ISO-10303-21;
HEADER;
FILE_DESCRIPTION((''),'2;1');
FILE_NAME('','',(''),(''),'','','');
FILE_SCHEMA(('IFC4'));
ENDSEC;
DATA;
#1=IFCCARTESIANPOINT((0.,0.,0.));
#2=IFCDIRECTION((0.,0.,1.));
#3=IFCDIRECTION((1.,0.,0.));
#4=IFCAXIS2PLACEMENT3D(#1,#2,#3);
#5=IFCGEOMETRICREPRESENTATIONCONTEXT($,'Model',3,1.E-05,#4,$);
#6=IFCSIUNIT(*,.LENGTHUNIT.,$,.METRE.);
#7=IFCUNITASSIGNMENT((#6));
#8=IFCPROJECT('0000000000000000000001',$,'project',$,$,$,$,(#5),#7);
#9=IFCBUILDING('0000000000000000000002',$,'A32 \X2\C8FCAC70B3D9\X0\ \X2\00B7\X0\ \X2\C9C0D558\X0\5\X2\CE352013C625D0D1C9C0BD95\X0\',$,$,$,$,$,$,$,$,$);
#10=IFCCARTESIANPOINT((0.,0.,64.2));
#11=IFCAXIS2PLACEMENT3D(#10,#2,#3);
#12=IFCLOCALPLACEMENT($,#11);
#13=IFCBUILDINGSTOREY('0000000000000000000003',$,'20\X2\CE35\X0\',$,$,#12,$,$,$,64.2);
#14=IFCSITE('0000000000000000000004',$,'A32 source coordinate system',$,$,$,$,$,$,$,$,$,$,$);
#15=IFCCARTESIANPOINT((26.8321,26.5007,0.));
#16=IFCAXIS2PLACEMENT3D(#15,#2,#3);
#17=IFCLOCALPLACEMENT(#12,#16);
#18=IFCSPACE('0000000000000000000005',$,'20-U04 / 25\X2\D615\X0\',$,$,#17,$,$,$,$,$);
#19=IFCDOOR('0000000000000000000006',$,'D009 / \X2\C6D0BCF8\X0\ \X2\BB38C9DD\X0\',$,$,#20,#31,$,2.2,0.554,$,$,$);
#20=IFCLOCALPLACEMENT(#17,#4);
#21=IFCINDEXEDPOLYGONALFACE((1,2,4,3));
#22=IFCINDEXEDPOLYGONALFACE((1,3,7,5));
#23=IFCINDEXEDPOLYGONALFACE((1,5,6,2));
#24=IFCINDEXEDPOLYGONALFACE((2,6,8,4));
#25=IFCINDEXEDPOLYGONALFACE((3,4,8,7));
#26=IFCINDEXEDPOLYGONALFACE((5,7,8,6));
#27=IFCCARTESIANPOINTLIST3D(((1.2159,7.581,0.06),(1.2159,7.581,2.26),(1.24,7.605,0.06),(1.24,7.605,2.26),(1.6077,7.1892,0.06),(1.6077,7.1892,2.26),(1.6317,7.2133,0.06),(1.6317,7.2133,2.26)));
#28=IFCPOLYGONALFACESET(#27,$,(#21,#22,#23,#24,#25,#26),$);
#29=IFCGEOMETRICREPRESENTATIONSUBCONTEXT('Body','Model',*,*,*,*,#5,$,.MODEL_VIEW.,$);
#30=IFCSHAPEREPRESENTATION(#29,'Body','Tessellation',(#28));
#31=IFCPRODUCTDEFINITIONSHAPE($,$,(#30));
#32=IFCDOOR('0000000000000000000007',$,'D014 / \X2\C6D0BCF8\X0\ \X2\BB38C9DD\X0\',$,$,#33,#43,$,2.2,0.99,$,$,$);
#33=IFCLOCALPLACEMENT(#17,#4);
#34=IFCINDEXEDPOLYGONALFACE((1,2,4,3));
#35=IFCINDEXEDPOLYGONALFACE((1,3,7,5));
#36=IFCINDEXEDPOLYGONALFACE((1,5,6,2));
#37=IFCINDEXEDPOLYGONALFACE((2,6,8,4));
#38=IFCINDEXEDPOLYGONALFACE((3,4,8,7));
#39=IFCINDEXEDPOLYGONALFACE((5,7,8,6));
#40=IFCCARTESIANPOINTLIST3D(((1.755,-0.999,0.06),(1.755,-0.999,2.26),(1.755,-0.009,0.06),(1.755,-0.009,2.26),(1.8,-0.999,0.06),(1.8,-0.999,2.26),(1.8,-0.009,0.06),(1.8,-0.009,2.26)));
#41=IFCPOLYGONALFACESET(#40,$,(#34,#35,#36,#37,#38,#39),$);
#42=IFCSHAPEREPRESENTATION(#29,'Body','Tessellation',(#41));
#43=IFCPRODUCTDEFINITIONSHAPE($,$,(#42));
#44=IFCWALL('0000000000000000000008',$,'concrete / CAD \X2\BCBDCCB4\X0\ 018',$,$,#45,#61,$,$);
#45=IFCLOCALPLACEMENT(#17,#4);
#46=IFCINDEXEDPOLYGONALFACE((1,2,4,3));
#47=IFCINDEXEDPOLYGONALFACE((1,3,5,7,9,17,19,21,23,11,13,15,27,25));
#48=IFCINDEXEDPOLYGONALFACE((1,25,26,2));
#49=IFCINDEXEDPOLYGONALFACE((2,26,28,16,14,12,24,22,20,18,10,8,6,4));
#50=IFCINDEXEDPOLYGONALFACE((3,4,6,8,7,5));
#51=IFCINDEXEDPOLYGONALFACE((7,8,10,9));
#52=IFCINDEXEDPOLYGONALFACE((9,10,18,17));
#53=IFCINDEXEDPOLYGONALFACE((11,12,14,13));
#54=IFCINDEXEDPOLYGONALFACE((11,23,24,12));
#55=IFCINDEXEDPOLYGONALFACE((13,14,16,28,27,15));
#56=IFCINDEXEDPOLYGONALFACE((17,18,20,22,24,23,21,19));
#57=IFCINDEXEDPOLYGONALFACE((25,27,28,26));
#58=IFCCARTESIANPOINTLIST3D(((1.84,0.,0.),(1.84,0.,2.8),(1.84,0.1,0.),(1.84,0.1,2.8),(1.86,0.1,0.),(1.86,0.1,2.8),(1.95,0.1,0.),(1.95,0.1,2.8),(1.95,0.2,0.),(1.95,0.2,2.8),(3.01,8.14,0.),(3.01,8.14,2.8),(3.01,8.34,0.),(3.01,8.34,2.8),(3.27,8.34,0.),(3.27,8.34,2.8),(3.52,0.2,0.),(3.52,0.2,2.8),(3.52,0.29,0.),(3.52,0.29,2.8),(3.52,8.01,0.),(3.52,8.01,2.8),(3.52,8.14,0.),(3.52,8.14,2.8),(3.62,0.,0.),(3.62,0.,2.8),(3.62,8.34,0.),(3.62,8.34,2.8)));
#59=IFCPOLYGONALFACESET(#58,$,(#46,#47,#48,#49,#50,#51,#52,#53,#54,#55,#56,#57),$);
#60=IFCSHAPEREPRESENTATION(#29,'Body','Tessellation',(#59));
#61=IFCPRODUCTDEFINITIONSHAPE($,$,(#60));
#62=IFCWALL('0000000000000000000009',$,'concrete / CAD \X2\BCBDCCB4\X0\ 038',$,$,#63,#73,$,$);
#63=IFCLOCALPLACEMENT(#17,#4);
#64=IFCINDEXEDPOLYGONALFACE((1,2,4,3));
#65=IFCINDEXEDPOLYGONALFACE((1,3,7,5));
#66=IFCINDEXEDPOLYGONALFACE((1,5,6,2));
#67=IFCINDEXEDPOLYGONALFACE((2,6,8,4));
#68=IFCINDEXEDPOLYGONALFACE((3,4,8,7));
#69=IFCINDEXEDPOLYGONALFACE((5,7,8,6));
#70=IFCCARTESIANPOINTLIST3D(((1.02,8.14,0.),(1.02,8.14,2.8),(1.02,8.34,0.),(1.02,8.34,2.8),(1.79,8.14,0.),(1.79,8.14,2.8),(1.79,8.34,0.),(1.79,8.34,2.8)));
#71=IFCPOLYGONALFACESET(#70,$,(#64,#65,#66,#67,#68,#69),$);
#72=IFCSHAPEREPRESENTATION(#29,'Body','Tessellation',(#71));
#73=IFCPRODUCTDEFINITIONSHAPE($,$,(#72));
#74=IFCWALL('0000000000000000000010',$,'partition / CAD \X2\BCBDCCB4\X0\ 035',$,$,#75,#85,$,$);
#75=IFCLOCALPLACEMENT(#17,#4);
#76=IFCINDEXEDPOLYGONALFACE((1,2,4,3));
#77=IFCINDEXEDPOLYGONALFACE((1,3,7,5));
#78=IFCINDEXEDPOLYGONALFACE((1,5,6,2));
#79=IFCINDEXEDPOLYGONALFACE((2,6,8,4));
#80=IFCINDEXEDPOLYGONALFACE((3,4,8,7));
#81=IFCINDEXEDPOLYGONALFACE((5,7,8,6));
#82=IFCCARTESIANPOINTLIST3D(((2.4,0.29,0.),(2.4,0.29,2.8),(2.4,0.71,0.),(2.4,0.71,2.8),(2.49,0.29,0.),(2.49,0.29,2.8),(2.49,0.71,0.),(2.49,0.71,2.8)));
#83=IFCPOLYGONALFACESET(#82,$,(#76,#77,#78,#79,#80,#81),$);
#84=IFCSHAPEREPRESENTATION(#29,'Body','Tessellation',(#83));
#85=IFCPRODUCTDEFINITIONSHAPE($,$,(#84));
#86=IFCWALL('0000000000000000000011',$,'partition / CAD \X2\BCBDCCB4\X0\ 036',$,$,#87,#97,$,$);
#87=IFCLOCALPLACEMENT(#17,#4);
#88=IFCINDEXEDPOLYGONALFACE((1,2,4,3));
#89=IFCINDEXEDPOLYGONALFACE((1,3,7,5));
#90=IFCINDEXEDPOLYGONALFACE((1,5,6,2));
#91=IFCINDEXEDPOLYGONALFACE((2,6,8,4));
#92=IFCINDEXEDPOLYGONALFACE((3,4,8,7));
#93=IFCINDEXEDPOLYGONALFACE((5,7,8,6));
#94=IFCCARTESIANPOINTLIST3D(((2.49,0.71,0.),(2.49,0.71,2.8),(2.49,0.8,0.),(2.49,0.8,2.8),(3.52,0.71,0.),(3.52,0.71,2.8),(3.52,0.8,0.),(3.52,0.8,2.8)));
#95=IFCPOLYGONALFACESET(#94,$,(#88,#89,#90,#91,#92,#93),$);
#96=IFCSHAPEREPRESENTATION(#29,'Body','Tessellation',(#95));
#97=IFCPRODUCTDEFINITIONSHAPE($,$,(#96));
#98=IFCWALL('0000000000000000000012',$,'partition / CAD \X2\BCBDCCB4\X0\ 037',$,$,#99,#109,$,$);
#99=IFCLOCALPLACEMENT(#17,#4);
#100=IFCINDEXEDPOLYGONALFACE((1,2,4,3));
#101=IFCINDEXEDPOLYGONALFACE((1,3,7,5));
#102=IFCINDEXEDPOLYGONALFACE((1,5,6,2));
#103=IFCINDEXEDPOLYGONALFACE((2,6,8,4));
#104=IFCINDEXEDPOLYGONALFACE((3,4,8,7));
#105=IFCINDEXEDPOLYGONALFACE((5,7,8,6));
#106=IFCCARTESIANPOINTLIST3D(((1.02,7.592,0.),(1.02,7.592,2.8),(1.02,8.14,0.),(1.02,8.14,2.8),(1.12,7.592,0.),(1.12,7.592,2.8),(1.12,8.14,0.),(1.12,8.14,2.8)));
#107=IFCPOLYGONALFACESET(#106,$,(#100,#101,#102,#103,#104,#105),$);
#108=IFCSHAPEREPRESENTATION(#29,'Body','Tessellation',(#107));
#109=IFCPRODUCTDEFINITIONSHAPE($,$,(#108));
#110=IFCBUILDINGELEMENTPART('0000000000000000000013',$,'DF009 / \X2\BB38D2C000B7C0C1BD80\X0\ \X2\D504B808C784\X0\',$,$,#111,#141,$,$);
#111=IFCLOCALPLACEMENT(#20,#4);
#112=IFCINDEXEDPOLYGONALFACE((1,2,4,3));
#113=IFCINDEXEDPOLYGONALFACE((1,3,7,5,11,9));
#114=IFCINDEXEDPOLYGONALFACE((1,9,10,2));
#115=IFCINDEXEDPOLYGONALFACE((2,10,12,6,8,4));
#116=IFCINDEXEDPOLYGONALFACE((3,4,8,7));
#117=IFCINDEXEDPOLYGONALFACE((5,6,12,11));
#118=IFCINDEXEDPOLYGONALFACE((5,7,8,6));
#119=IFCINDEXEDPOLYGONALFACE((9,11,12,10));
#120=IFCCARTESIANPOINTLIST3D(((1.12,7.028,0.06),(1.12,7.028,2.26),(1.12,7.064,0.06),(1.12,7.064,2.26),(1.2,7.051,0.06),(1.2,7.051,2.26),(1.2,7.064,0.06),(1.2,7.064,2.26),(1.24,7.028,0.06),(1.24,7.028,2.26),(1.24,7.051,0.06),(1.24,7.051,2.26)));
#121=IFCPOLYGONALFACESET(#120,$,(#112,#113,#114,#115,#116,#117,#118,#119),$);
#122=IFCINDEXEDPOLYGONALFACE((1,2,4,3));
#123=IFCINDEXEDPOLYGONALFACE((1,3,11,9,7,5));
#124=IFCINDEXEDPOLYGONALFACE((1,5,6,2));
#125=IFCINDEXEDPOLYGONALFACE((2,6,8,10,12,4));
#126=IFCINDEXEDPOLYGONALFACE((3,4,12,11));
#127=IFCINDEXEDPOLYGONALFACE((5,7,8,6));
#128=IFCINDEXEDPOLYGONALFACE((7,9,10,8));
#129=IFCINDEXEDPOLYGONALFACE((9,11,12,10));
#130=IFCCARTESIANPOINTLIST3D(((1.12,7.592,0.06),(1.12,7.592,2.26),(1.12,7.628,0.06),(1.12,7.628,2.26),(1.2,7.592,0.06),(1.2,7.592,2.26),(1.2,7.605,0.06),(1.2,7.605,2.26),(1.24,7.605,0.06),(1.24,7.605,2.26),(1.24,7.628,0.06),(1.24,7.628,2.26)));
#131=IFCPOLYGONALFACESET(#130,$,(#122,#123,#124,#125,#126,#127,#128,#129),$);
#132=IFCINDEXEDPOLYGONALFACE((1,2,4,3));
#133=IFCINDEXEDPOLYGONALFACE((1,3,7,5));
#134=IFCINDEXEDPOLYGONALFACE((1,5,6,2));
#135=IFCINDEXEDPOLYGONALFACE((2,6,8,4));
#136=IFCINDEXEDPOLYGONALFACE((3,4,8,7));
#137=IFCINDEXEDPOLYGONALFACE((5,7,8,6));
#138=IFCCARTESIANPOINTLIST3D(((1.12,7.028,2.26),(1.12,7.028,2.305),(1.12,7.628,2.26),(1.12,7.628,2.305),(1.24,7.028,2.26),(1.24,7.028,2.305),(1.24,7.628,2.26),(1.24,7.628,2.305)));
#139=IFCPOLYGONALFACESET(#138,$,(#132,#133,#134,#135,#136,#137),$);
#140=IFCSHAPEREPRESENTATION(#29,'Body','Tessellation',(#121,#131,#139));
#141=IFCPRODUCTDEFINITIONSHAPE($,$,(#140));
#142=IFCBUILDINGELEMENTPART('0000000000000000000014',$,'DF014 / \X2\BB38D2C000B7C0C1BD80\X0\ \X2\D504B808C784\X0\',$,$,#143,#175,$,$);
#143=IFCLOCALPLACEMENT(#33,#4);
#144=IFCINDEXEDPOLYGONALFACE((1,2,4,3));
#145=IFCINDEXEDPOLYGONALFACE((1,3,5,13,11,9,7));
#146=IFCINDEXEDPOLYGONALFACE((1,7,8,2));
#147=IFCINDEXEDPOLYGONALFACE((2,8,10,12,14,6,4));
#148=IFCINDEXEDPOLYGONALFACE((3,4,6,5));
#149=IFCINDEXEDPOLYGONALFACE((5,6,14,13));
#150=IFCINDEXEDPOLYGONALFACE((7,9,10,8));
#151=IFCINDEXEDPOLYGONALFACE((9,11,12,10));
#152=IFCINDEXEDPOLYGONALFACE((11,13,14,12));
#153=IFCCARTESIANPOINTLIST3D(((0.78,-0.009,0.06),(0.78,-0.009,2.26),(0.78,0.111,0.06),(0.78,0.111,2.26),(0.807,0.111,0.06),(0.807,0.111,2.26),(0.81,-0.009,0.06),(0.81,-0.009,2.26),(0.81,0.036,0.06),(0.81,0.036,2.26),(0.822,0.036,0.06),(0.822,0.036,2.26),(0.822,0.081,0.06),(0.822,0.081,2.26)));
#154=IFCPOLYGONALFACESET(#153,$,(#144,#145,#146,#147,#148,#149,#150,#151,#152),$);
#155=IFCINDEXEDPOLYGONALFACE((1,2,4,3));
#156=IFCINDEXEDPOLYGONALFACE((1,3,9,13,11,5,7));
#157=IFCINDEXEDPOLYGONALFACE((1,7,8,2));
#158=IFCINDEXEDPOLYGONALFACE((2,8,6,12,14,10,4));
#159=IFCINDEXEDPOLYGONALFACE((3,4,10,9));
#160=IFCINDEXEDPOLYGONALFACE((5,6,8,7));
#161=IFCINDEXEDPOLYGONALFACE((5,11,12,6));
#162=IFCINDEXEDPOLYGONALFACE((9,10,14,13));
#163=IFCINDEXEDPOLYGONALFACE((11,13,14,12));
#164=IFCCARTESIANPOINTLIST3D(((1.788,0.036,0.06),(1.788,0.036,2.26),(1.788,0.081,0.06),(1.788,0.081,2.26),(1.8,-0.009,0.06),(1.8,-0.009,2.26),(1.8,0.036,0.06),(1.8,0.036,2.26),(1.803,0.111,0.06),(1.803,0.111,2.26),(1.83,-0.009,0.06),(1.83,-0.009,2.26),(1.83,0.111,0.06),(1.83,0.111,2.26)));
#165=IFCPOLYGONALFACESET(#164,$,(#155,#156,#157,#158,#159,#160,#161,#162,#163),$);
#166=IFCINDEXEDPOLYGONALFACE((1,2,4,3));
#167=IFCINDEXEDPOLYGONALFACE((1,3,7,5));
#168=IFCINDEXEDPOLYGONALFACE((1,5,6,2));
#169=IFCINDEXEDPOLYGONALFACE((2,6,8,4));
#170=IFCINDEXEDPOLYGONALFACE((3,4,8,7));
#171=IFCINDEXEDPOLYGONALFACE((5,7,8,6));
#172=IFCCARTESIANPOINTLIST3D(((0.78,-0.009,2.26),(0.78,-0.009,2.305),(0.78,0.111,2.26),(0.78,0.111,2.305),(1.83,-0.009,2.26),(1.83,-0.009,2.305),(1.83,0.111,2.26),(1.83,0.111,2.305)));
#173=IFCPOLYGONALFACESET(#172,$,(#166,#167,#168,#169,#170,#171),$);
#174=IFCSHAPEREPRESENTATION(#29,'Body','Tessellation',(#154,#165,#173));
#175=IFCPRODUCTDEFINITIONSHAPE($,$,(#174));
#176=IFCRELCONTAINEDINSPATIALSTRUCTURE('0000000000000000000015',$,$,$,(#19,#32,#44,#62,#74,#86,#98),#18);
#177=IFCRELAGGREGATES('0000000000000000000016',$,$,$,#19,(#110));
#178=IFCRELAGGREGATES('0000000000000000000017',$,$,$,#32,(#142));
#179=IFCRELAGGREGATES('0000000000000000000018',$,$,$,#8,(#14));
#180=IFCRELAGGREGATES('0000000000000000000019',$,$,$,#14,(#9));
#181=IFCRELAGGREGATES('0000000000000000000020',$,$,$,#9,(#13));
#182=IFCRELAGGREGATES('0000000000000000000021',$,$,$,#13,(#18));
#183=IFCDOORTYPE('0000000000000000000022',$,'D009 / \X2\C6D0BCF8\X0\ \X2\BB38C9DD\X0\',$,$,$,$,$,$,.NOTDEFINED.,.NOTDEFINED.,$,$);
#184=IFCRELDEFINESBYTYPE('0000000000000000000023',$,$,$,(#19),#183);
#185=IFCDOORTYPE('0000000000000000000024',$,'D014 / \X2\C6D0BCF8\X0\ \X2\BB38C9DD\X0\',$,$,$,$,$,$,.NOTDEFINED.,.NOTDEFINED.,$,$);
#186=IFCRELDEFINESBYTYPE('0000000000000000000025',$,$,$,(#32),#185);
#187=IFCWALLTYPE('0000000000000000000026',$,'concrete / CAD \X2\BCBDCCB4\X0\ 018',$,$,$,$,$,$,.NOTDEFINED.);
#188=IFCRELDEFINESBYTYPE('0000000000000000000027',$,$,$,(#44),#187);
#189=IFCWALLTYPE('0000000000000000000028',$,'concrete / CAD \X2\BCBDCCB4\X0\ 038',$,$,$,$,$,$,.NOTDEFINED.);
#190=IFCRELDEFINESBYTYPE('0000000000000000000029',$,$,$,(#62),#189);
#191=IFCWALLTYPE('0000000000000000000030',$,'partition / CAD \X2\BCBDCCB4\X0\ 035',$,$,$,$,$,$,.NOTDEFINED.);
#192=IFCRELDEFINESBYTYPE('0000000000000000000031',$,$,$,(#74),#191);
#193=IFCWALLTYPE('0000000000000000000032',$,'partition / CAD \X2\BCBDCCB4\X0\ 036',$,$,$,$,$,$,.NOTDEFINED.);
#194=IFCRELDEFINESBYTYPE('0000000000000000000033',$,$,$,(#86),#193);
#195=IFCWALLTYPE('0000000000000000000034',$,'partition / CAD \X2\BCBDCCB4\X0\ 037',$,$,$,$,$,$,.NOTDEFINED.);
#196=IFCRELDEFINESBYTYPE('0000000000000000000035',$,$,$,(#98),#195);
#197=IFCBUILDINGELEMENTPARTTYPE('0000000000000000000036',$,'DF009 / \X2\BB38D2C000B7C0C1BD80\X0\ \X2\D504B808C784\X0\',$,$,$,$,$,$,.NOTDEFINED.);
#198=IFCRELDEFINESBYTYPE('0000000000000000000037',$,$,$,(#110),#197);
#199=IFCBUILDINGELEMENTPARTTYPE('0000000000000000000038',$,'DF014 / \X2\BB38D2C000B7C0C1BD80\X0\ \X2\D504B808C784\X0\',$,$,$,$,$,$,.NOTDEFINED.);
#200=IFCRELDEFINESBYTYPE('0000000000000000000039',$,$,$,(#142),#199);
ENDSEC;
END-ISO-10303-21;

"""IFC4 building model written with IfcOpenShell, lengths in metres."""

from ifc_helpers import new_model, si_unit, frame, origin, origin_with_axes, place, context, subcontext, project, spatial, polyline, outline, extrude, source, transform, mapped, type_object, type_shapes, element, aggregate, save


model = new_model("IFC4")

# Units and contexts
model_context = context("Model", 3, precision=1e-05, world=origin_with_axes())
body_context = subcontext(model_context, "Body", "Model", "MODEL_VIEW")
ifc_project = project(units=[si_unit("LENGTHUNIT", "METRE")], contexts=[model_context])

# Site, building, storey, space
storey_placement = place(None, frame((0.0, 0.0, 64.2), z_axis=(0.0, 0.0, 1.0), x_axis=(1.0, 0.0, 0.0)))
space_placement = place(storey_placement, frame((26.8321, 26.5007, 0.0), z_axis=(0.0, 0.0, 1.0), x_axis=(1.0, 0.0, 0.0)))
site = spatial("IfcSite", under=ifc_project, Name="A32 source coordinate system")
building = spatial("IfcBuilding", under=site, Name="A32 주거동 · 지하5층–옥탑지붕")
storey = spatial("IfcBuildingStorey", under=building, at=storey_placement, Name="20층", Elevation=64.2)
space = spatial("IfcSpace", under=storey, at=space_placement, Name="20-U04 / 25형")

# Doors
door_type_1 = type_object("IfcDoorType", Name="D009 / 원본 문짝", OperationType="NOTDEFINED", PredefinedType="NOTDEFINED")
shared_shape_1 = source(origin(), body_context, "Body", "SweptSolid", [
    extrude(outline(polyline([(1.24, 7.605), (1.6317, 7.2133), (1.6077, 7.1892), (1.2159, 7.581), (1.24, 7.605)])), frame((0.0, 0.0, 0.06)), (0.0, 0.0, 1.0), 2.2),
])
type_shapes(door_type_1, [shared_shape_1])
door_1_placement = place(space_placement, origin_with_axes())
door_1 = element("IfcDoor", 1, at=door_1_placement, inside=space, type_object=door_type_1, Name="D009 / 원본 문짝", OverallHeight=2.2, OverallWidth=0.554, context=body_context, shape_type="MappedRepresentation", body=[
    mapped(shared_shape_1, transform((0.0, 0.0, 0.0), scale=1.0)),
])
door_type_2 = type_object("IfcDoorType", Name="D014 / 원본 문짝", OperationType="NOTDEFINED", PredefinedType="NOTDEFINED")
shared_shape_2 = source(origin(), body_context, "Body", "SweptSolid", [
    extrude(outline(polyline([(1.8, -0.009), (1.8, -0.999), (1.755, -0.999), (1.755, -0.009), (1.8, -0.009)])), frame((0.0, 0.0, 0.06)), (0.0, 0.0, 1.0), 2.2),
])
type_shapes(door_type_2, [shared_shape_2])
door_2_placement = place(space_placement, origin_with_axes())
door_2 = element("IfcDoor", 2, at=door_2_placement, inside=space, type_object=door_type_2, Name="D014 / 원본 문짝", OverallHeight=2.2, OverallWidth=0.99, context=body_context, shape_type="MappedRepresentation", body=[
    mapped(shared_shape_2, transform((0.0, 0.0, 0.0), scale=1.0)),
])

# Walls
wall_type_1 = type_object("IfcWallType", Name="concrete / CAD 벽체 018", PredefinedType="NOTDEFINED")
shared_shape_3 = source(origin(), body_context, "Body", "SweptSolid", [
    extrude(outline(polyline([(3.27, 8.34), (3.27, 8.34), (3.62, 8.34), (3.62, 0.0), (1.84, 0.0), (1.84, 0.1), (1.86, 0.1), (1.95, 0.1), (1.95, 0.2), (3.52, 0.2), (3.52, 0.29), (3.52, 8.01), (3.52, 8.14), (3.01, 8.14), (3.01, 8.34), (3.27, 8.34)])), origin(), (0.0, 0.0, 1.0), 2.8),
])
type_shapes(wall_type_1, [shared_shape_3])
wall_1_placement = place(space_placement, origin_with_axes())
element("IfcWall", 3, at=wall_1_placement, inside=space, type_object=wall_type_1, Name="concrete / CAD 벽체 018", context=body_context, shape_type="MappedRepresentation", body=[
    mapped(shared_shape_3, transform((0.0, 0.0, 0.0), scale=1.0)),
])
wall_type_2 = type_object("IfcWallType", Name="concrete / CAD 벽체 038", PredefinedType="NOTDEFINED")
shared_shape_4 = source(origin(), body_context, "Body", "SweptSolid", [
    extrude(outline(polyline([(1.02, 8.14), (1.02, 8.34), (1.79, 8.34), (1.79, 8.14), (1.02, 8.14)])), origin(), (0.0, 0.0, 1.0), 2.8),
])
type_shapes(wall_type_2, [shared_shape_4])
wall_2_placement = place(space_placement, origin_with_axes())
element("IfcWall", 4, at=wall_2_placement, inside=space, type_object=wall_type_2, Name="concrete / CAD 벽체 038", context=body_context, shape_type="MappedRepresentation", body=[
    mapped(shared_shape_4, transform((0.0, 0.0, 0.0), scale=1.0)),
])
wall_type_3 = type_object("IfcWallType", Name="partition / CAD 벽체 035", PredefinedType="NOTDEFINED")
shared_shape_5 = source(origin(), body_context, "Body", "SweptSolid", [
    extrude(outline(polyline([(2.49, 0.71), (2.49, 0.29), (2.4, 0.29), (2.4, 0.71), (2.49, 0.71)])), origin(), (0.0, 0.0, 1.0), 2.8),
])
type_shapes(wall_type_3, [shared_shape_5])
wall_3_placement = place(space_placement, origin_with_axes())
element("IfcWall", 5, at=wall_3_placement, inside=space, type_object=wall_type_3, Name="partition / CAD 벽체 035", context=body_context, shape_type="MappedRepresentation", body=[
    mapped(shared_shape_5, transform((0.0, 0.0, 0.0), scale=1.0)),
])
wall_type_4 = type_object("IfcWallType", Name="partition / CAD 벽체 036", PredefinedType="NOTDEFINED")
shared_shape_6 = source(origin(), body_context, "Body", "SweptSolid", [
    extrude(outline(polyline([(2.49, 0.8), (3.52, 0.8), (3.52, 0.71), (2.49, 0.71), (2.49, 0.8)])), origin(), (0.0, 0.0, 1.0), 2.8),
])
type_shapes(wall_type_4, [shared_shape_6])
wall_4_placement = place(space_placement, origin_with_axes())
element("IfcWall", 6, at=wall_4_placement, inside=space, type_object=wall_type_4, Name="partition / CAD 벽체 036", context=body_context, shape_type="MappedRepresentation", body=[
    mapped(shared_shape_6, transform((0.0, 0.0, 0.0), scale=1.0)),
])
wall_type_5 = type_object("IfcWallType", Name="partition / CAD 벽체 037", PredefinedType="NOTDEFINED")
shared_shape_7 = source(origin(), body_context, "Body", "SweptSolid", [
    extrude(outline(polyline([(1.02, 7.592), (1.02, 8.14), (1.12, 8.14), (1.12, 7.592), (1.02, 7.592)])), origin(), (0.0, 0.0, 1.0), 2.8),
])
type_shapes(wall_type_5, [shared_shape_7])
wall_5_placement = place(space_placement, origin_with_axes())
element("IfcWall", 7, at=wall_5_placement, inside=space, type_object=wall_type_5, Name="partition / CAD 벽체 037", context=body_context, shape_type="MappedRepresentation", body=[
    mapped(shared_shape_7, transform((0.0, 0.0, 0.0), scale=1.0)),
])

# Building element parts
building_element_part_type_1 = type_object("IfcBuildingElementPartType", Name="DF009 / 문틀·상부 프레임", PredefinedType="NOTDEFINED")
shared_shape_8 = source(origin(), body_context, "Body", "SweptSolid", [
    extrude(outline(polyline([(1.12, 7.064), (1.2, 7.064), (1.2, 7.051), (1.24, 7.051), (1.24, 7.028), (1.12, 7.028), (1.12, 7.064)])), frame((0.0, 0.0, 0.06)), (0.0, 0.0, 1.0), 2.2),
    extrude(outline(polyline([(1.24, 7.628), (1.24, 7.605), (1.2, 7.605), (1.2, 7.592), (1.12, 7.592), (1.12, 7.628), (1.24, 7.628)])), frame((0.0, 0.0, 0.06)), (0.0, 0.0, 1.0), 2.2),
    extrude(outline(polyline([(1.12, 7.028), (1.12, 7.628), (1.24, 7.628), (1.24, 7.028), (1.12, 7.028)])), frame((0.0, 0.0, 2.26)), (0.0, 0.0, 1.0), 0.045),
])
type_shapes(building_element_part_type_1, [shared_shape_8])
building_element_part_1_placement = place(door_1_placement, origin_with_axes())
building_element_part_1 = element("IfcBuildingElementPart", 8, at=building_element_part_1_placement, type_object=building_element_part_type_1, Name="DF009 / 문틀·상부 프레임", context=body_context, shape_type="MappedRepresentation", body=[
    mapped(shared_shape_8, transform((0.0, 0.0, 0.0), scale=1.0)),
])
aggregate(door_1, [building_element_part_1])
building_element_part_type_2 = type_object("IfcBuildingElementPartType", Name="DF014 / 문틀·상부 프레임", PredefinedType="NOTDEFINED")
shared_shape_9 = source(origin(), body_context, "Body", "SweptSolid", [
    extrude(outline(polyline([(0.78, 0.111), (0.807, 0.111), (0.822, 0.081), (0.822, 0.036), (0.81, 0.036), (0.81, -0.009), (0.78, -0.009), (0.78, 0.111)])), frame((0.0, 0.0, 0.06)), (0.0, 0.0, 1.0), 2.2),
    extrude(outline(polyline([(1.8, -0.009), (1.8, 0.036), (1.788, 0.036), (1.788, 0.081), (1.803, 0.111), (1.83, 0.111), (1.83, -0.009), (1.8, -0.009)])), frame((0.0, 0.0, 0.06)), (0.0, 0.0, 1.0), 2.2),
    extrude(outline(polyline([(0.78, -0.009), (0.78, 0.111), (1.83, 0.111), (1.83, -0.009), (0.78, -0.009)])), frame((0.0, 0.0, 2.26)), (0.0, 0.0, 1.0), 0.045),
])
type_shapes(building_element_part_type_2, [shared_shape_9])
building_element_part_2_placement = place(door_2_placement, origin_with_axes())
building_element_part_2 = element("IfcBuildingElementPart", 9, at=building_element_part_2_placement, type_object=building_element_part_type_2, Name="DF014 / 문틀·상부 프레임", context=body_context, shape_type="MappedRepresentation", body=[
    mapped(shared_shape_9, transform((0.0, 0.0, 0.0), scale=1.0)),
])
aggregate(door_2, [building_element_part_2])

save(model, "model.ifc")
